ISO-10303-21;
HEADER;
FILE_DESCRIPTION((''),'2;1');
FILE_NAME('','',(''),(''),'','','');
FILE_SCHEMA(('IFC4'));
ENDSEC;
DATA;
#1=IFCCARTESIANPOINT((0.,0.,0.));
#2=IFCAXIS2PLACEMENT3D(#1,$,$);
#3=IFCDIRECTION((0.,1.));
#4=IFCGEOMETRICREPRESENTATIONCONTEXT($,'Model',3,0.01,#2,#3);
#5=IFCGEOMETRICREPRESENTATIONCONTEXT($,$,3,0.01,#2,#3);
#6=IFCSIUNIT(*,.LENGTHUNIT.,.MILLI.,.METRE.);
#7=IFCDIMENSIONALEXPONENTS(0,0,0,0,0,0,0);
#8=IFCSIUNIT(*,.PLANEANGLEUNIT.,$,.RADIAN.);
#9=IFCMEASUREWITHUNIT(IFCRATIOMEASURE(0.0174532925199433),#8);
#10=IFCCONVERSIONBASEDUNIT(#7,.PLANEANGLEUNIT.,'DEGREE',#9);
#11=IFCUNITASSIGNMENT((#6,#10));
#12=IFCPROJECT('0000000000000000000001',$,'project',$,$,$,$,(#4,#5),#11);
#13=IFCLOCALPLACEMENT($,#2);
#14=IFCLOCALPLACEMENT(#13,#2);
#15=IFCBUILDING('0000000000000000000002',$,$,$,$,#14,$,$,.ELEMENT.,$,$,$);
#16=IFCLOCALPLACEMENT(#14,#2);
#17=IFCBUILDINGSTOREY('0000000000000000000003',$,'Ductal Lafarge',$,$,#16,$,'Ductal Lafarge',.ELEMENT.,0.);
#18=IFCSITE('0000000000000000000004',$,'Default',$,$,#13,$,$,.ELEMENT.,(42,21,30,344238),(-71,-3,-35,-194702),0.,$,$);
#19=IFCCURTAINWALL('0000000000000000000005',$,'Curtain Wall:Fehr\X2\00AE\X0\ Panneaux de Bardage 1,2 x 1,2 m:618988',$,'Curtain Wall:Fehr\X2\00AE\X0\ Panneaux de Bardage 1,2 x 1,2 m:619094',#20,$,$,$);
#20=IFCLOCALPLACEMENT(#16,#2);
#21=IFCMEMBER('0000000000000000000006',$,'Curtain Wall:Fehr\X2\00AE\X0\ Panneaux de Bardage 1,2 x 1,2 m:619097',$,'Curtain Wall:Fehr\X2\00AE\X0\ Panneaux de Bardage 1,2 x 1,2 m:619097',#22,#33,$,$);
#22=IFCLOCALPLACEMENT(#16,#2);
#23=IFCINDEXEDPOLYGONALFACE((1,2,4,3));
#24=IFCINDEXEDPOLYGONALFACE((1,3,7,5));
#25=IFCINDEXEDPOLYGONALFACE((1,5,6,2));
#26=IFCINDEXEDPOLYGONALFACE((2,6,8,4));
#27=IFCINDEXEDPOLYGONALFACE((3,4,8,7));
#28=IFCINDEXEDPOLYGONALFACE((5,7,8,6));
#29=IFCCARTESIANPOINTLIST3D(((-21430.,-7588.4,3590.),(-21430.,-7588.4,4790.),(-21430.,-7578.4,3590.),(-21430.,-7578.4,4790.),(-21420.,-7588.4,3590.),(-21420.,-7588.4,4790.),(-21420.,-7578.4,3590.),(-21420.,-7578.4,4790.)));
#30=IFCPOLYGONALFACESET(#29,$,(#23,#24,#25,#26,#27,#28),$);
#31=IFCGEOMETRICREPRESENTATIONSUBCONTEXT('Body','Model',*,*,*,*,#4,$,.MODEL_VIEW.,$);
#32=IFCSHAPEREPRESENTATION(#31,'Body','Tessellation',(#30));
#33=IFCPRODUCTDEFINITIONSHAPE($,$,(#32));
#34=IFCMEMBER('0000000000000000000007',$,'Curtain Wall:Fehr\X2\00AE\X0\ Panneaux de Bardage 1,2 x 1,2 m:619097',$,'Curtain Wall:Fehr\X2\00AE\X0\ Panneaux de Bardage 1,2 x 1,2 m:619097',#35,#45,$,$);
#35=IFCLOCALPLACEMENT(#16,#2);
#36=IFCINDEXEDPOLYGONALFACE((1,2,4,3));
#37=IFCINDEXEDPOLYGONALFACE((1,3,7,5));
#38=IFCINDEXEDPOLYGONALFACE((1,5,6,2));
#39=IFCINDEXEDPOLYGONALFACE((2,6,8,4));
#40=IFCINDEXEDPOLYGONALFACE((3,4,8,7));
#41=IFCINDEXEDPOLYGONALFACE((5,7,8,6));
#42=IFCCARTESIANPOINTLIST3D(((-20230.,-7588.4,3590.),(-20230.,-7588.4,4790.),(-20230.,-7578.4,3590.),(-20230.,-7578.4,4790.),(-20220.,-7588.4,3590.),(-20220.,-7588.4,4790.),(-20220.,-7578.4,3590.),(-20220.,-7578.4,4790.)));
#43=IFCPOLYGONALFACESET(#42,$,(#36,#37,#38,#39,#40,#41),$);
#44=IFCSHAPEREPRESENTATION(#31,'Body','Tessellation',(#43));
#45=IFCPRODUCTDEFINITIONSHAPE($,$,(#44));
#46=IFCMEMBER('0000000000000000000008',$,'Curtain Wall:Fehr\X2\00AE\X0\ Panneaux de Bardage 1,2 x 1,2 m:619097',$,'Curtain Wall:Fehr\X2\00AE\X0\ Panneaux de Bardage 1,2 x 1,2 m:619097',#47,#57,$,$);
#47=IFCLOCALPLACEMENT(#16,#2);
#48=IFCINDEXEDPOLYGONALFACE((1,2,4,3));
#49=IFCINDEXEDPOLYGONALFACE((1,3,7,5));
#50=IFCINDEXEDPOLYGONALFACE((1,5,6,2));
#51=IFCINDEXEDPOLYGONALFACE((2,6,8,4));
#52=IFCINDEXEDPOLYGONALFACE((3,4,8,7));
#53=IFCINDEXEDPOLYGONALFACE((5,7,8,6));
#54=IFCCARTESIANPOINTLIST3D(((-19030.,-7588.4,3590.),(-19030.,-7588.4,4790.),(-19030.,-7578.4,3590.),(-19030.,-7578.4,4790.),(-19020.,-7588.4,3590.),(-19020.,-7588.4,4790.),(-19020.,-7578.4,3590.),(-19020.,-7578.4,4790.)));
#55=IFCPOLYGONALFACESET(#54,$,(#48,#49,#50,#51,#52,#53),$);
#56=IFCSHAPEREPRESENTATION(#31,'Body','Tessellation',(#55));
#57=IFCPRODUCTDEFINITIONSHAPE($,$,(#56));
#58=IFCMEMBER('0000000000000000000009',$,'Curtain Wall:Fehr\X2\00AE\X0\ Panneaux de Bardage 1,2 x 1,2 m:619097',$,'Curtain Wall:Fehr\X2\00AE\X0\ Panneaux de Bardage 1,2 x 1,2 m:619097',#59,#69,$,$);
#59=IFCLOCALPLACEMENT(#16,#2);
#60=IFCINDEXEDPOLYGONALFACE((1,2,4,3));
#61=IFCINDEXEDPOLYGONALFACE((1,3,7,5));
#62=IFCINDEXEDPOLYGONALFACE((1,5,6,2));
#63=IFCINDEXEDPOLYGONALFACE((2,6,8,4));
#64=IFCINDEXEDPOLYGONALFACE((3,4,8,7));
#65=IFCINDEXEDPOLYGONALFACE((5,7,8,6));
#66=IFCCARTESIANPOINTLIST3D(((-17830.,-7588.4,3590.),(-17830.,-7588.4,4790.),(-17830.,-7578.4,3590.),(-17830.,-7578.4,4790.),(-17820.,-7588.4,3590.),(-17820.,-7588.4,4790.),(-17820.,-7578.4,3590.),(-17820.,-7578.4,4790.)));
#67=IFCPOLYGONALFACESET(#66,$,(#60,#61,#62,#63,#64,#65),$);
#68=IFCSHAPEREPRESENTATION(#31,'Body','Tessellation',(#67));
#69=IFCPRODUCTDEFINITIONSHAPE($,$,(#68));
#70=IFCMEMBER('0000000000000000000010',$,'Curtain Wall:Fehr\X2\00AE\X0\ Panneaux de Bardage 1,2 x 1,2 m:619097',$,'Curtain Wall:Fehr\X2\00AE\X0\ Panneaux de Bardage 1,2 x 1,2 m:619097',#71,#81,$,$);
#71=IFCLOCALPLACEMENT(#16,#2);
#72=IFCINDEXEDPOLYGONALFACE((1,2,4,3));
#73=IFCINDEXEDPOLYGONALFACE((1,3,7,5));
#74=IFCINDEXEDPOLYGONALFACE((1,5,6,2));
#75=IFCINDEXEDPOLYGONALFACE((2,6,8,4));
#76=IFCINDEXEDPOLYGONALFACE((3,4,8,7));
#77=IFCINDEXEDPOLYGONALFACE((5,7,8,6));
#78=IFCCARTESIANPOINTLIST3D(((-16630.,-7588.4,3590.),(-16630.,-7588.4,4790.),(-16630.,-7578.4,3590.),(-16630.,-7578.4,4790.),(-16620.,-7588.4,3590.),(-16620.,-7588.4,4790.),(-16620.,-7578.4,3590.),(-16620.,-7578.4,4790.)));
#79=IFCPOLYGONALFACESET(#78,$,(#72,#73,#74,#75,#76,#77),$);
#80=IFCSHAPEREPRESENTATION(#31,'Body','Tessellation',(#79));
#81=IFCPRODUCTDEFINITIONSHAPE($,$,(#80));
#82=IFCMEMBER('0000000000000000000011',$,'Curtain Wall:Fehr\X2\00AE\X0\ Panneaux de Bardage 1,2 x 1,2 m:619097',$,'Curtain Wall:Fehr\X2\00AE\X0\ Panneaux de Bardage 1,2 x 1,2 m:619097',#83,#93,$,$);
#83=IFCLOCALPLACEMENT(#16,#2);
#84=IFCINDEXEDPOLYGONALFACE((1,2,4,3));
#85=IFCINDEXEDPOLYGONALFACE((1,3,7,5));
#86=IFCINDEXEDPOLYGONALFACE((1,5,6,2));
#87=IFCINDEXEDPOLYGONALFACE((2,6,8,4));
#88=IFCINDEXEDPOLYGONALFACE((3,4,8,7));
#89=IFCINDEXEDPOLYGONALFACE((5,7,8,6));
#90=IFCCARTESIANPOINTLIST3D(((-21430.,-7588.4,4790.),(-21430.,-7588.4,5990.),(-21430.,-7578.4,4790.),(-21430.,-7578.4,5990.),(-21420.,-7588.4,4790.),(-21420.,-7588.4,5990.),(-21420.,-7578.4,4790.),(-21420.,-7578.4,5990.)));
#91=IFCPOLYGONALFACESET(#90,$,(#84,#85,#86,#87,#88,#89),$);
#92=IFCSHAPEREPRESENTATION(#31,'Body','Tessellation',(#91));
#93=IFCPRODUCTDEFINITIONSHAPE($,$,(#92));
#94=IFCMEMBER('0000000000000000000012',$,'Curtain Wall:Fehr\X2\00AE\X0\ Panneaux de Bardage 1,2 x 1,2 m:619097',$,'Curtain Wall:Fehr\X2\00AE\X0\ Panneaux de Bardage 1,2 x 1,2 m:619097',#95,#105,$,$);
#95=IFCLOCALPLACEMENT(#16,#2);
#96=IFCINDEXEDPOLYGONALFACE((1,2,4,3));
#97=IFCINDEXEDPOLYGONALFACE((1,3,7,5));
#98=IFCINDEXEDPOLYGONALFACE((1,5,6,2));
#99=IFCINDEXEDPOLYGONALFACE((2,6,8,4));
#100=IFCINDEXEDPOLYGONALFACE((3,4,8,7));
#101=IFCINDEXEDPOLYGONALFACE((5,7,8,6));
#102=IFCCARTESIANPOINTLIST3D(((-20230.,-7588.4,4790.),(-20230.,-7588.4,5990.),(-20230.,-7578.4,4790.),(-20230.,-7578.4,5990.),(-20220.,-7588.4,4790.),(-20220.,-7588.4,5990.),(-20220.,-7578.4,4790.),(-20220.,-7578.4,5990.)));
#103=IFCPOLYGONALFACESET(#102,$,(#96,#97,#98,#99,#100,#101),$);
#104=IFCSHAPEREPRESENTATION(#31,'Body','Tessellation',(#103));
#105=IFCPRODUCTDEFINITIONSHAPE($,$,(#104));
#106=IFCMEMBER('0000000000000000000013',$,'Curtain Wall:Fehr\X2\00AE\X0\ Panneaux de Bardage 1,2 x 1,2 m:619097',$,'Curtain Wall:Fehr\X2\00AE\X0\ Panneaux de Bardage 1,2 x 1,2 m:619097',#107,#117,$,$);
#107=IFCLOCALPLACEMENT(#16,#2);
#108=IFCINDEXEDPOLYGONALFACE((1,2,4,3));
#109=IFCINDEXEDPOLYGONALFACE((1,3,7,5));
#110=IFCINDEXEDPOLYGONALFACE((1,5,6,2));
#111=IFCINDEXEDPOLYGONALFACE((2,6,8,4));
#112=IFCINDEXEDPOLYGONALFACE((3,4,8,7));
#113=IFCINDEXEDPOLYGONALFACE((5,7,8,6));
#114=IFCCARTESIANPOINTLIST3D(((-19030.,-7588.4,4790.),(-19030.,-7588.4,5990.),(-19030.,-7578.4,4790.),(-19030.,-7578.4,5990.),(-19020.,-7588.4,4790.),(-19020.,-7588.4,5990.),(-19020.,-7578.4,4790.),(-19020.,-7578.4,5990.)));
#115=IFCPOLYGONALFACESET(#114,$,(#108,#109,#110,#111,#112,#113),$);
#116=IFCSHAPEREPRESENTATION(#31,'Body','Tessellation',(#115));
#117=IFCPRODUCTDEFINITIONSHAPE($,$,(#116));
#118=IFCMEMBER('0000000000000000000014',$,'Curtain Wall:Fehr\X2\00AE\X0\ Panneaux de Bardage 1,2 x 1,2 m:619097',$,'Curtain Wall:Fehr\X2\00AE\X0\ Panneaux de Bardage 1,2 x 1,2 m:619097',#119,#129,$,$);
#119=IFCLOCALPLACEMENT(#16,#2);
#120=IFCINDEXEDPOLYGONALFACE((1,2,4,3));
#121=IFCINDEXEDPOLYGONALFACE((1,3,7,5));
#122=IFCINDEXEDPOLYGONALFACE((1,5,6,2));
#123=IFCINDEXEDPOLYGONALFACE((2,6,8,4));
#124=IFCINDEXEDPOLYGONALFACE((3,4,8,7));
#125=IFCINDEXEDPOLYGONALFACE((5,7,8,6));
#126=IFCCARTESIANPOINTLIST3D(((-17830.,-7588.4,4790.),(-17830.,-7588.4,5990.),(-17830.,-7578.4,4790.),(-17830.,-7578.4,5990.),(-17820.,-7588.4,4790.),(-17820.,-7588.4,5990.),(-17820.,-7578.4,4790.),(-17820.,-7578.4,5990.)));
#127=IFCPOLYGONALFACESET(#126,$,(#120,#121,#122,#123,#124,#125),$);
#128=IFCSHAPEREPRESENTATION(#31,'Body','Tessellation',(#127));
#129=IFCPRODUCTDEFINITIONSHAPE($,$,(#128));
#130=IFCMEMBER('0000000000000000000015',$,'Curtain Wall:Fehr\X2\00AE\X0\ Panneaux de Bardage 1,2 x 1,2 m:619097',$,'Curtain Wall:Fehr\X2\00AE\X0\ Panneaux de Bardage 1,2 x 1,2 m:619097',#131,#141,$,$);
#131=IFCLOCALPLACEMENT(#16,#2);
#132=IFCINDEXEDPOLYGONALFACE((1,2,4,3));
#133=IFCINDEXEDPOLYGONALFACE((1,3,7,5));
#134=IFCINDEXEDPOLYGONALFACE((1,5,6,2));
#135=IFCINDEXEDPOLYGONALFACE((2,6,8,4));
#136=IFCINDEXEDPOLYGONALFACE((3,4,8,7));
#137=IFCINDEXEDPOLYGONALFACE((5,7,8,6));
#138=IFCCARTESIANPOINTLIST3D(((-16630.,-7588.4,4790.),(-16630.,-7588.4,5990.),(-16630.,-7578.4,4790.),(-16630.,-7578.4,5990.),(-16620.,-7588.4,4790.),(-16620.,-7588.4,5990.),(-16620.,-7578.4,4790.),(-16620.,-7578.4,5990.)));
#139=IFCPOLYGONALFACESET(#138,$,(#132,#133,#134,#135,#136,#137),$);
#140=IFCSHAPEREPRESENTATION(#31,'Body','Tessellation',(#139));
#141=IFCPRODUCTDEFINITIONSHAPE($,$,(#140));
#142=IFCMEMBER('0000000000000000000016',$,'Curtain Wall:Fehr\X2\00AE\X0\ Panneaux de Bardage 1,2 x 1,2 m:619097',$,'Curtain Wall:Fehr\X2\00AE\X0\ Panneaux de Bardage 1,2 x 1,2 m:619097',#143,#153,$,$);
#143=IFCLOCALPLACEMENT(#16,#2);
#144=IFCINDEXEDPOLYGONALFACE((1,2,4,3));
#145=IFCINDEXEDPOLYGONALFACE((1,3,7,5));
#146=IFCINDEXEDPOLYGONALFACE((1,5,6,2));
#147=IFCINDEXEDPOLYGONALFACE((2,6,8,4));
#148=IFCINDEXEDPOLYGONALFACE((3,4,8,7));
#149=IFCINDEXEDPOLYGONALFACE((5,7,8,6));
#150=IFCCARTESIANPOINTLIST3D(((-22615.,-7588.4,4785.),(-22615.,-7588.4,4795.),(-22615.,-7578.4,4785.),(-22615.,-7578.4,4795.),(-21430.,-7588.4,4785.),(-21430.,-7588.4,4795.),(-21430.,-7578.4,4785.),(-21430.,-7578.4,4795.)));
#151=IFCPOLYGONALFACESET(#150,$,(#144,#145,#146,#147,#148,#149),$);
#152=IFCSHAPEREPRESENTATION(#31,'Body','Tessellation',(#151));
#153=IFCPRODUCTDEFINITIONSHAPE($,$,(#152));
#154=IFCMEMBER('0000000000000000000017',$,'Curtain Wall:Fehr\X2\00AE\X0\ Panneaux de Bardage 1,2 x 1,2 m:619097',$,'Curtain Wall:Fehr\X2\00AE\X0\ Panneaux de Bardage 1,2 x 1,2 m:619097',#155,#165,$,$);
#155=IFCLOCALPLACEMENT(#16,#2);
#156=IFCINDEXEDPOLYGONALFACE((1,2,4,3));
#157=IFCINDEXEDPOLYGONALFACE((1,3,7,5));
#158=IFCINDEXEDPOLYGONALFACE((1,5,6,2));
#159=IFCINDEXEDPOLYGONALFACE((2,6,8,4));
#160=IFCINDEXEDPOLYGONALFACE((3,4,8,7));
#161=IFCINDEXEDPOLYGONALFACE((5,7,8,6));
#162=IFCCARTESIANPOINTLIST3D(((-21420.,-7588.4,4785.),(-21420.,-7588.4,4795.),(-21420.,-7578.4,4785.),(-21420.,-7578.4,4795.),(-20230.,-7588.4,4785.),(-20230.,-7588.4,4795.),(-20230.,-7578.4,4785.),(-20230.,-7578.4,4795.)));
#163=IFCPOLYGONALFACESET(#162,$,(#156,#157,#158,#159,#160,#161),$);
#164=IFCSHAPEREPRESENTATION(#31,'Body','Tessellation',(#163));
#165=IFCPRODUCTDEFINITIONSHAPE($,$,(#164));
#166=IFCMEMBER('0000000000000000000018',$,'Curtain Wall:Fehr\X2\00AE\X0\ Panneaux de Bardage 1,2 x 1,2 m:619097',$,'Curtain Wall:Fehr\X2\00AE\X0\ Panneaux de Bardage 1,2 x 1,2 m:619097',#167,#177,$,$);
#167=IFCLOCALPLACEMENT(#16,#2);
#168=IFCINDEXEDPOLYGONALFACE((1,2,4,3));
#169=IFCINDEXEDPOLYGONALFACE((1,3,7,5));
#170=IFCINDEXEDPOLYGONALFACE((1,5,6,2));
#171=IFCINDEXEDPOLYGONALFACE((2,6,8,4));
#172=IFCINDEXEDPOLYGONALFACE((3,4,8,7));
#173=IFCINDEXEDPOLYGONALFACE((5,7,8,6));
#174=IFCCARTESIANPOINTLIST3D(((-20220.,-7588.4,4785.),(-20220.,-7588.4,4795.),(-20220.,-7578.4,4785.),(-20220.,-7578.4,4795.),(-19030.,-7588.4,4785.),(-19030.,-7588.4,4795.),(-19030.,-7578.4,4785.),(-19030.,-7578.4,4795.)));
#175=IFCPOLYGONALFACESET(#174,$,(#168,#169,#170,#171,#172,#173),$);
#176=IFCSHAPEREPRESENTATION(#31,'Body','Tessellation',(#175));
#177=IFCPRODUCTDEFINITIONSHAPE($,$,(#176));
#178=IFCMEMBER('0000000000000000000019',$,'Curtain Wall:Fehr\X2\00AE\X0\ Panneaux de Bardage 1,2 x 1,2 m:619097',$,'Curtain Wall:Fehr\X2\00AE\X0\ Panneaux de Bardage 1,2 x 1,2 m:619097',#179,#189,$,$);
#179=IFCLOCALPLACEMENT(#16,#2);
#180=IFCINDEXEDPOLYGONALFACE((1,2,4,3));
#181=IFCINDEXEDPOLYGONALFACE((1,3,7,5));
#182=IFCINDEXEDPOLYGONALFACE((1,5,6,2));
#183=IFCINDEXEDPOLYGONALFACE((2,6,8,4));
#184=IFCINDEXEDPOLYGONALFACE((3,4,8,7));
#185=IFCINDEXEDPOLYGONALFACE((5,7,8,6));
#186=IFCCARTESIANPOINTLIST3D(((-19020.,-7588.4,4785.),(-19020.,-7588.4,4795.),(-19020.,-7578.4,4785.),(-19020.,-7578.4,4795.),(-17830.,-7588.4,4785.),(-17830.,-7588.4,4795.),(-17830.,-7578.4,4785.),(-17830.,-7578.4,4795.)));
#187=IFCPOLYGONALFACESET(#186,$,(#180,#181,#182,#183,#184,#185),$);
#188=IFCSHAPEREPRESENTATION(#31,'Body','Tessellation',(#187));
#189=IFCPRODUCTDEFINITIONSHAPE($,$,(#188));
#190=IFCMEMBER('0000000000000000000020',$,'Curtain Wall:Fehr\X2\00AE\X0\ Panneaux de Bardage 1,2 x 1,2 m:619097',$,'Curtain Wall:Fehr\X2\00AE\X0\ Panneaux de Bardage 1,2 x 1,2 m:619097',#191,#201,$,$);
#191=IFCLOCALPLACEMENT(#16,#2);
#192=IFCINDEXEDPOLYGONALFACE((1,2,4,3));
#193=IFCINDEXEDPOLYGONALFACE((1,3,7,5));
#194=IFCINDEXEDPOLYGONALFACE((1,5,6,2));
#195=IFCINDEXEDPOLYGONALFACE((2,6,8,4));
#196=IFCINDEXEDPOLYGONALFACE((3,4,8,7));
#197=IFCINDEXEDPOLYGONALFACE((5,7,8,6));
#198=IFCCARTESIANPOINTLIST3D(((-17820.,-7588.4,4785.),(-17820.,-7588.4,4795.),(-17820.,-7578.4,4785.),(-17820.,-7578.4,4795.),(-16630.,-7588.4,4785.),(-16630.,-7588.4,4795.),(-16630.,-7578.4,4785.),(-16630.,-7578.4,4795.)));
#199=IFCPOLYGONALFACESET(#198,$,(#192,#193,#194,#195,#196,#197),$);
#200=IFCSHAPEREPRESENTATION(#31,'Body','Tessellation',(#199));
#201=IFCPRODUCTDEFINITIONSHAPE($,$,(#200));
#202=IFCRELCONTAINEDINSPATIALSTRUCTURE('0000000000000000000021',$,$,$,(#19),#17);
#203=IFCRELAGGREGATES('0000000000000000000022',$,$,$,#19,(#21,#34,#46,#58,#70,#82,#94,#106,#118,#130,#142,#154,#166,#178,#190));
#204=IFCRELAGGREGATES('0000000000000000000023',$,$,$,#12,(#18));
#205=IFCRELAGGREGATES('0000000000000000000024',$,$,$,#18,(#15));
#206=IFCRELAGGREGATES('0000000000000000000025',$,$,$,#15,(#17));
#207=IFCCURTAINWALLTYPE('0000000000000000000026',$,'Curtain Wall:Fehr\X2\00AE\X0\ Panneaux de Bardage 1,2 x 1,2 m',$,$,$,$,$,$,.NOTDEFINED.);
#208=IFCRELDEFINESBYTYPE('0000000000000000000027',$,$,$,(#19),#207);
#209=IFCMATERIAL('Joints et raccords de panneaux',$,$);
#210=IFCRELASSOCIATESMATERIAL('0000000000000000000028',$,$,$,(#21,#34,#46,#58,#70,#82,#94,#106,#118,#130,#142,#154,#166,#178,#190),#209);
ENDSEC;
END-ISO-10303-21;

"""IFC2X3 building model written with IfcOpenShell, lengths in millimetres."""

from ifc_helpers import new_model, entity, si_unit, converted_unit, direction, frame, frame_2d, origin, origin_2d_with_axis, place, context, subcontext, project, spatial, rectangle, extrude, material, type_object, element, aggregate, save


model = new_model("IFC2X3")

# Units and contexts
model_context = context("Model", 3, precision=0.01, world=origin(), true_north=direction((0.0, 1.0)))
context_of_model = context(None, 3, precision=0.01, world=origin(), true_north=direction((0.0, 1.0)))
body_context = subcontext(model_context, "Body", "Model", "MODEL_VIEW")
ifc_project = project(units=[si_unit("LENGTHUNIT", "METRE", prefix="MILLI"), converted_unit("PLANEANGLEUNIT", "DEGREE", entity("IfcRatioMeasure", 0.0174532925199433), si_unit("PLANEANGLEUNIT", "RADIAN"), dimensions=[0, 0, 0, 0, 0, 0, 0])], contexts=[model_context, context_of_model])

# Site, building, storey
site_placement = place(None, origin())
site = spatial("IfcSite", under=ifc_project, at=site_placement, Name="Default", CompositionType="ELEMENT", RefLatitude=(42, 21, 30, 344238), RefLongitude=(-71, -3, -35, -194702), RefElevation=0.0)
building_placement = place(site_placement, origin())
building = spatial("IfcBuilding", under=site, at=building_placement, CompositionType="ELEMENT")
storey_placement = place(building_placement, origin())
storey = spatial("IfcBuildingStorey", under=building, at=storey_placement, Name="Ductal Lafarge", LongName="Ductal Lafarge", CompositionType="ELEMENT", Elevation=0.0)

# Curtain wall, members
curtain_wall_type = type_object("IfcCurtainWallType", Name="Curtain Wall:Fehr® Panneaux de Bardage 1,2 x 1,2 m", PredefinedType="NOTDEFINED")
curtain_wall_placement = place(storey_placement, origin())
curtain_wall = element("IfcCurtainWall", 1, at=curtain_wall_placement, inside=storey, type_object=curtain_wall_type, Name="Curtain Wall:Fehr® Panneaux de Bardage 1,2 x 1,2 m:618988", ObjectType="Curtain Wall:Fehr® Panneaux de Bardage 1,2 x 1,2 m:619094")
ifc_material = material(Name="Joints et raccords de panneaux")
member_1_placement = place(curtain_wall_placement, frame((-21430.0, -7588.4, 3590.0)))
member_1 = element("IfcMember", 2, at=member_1_placement, material=ifc_material, Name="Curtain Wall:Fehr® Panneaux de Bardage 1,2 x 1,2 m:619097", ObjectType="Curtain Wall:Fehr® Panneaux de Bardage 1,2 x 1,2 m:619097", context=body_context, shape_type="SweptSolid", body=[
    extrude(rectangle(XDim=10.0, YDim=10.0, at=origin_2d_with_axis()), frame((5.0, 5.0, 0.0), z_axis=(0.0, 0.0, 1.0), x_axis=(0.0, 1.0, 0.0)), (0.0, 0.0, 1.0), 1200.0),
])
member_2_placement = place(curtain_wall_placement, frame((-20230.0, -7588.4, 3590.0)))
member_2 = element("IfcMember", 3, at=member_2_placement, material=ifc_material, Name="Curtain Wall:Fehr® Panneaux de Bardage 1,2 x 1,2 m:619097", ObjectType="Curtain Wall:Fehr® Panneaux de Bardage 1,2 x 1,2 m:619097", context=body_context, shape_type="SweptSolid", body=[
    extrude(rectangle(XDim=10.0, YDim=10.0, at=origin_2d_with_axis()), frame((5.0, 5.0, 0.0), z_axis=(0.0, 0.0, 1.0), x_axis=(0.0, 1.0, 0.0)), (0.0, 0.0, 1.0), 1200.0),
])
member_3_placement = place(curtain_wall_placement, frame((-19030.0, -7588.4, 3590.0)))
member_3 = element("IfcMember", 4, at=member_3_placement, material=ifc_material, Name="Curtain Wall:Fehr® Panneaux de Bardage 1,2 x 1,2 m:619097", ObjectType="Curtain Wall:Fehr® Panneaux de Bardage 1,2 x 1,2 m:619097", context=body_context, shape_type="SweptSolid", body=[
    extrude(rectangle(XDim=10.0, YDim=10.0, at=origin_2d_with_axis()), frame((5.0, 5.0, 0.0), z_axis=(0.0, 0.0, 1.0), x_axis=(0.0, 1.0, 0.0)), (0.0, 0.0, 1.0), 1200.0),
])
member_4_placement = place(curtain_wall_placement, frame((-17830.0, -7588.4, 3590.0)))
member_4 = element("IfcMember", 5, at=member_4_placement, material=ifc_material, Name="Curtain Wall:Fehr® Panneaux de Bardage 1,2 x 1,2 m:619097", ObjectType="Curtain Wall:Fehr® Panneaux de Bardage 1,2 x 1,2 m:619097", context=body_context, shape_type="SweptSolid", body=[
    extrude(rectangle(XDim=10.0, YDim=10.0, at=origin_2d_with_axis()), frame((5.0, 5.0, 0.0), z_axis=(0.0, 0.0, 1.0), x_axis=(0.0, 1.0, 0.0)), (0.0, 0.0, 1.0), 1200.0),
])
member_5_placement = place(curtain_wall_placement, frame((-16630.0, -7588.4, 3590.0)))
member_5 = element("IfcMember", 6, at=member_5_placement, material=ifc_material, Name="Curtain Wall:Fehr® Panneaux de Bardage 1,2 x 1,2 m:619097", ObjectType="Curtain Wall:Fehr® Panneaux de Bardage 1,2 x 1,2 m:619097", context=body_context, shape_type="SweptSolid", body=[
    extrude(rectangle(XDim=10.0, YDim=10.0, at=origin_2d_with_axis()), frame((5.0, 5.0, 0.0), z_axis=(0.0, 0.0, 1.0), x_axis=(0.0, 1.0, 0.0)), (0.0, 0.0, 1.0), 1200.0),
])
member_6_placement = place(curtain_wall_placement, frame((-21430.0, -7588.4, 4790.0)))
member_6 = element("IfcMember", 7, at=member_6_placement, material=ifc_material, Name="Curtain Wall:Fehr® Panneaux de Bardage 1,2 x 1,2 m:619097", ObjectType="Curtain Wall:Fehr® Panneaux de Bardage 1,2 x 1,2 m:619097", context=body_context, shape_type="SweptSolid", body=[
    extrude(rectangle(XDim=10.0, YDim=10.0, at=origin_2d_with_axis()), frame((5.0, 5.0, 0.0), z_axis=(0.0, 0.0, 1.0), x_axis=(0.0, 1.0, 0.0)), (0.0, 0.0, 1.0), 1200.0),
])
member_7_placement = place(curtain_wall_placement, frame((-20230.0, -7588.4, 4790.0)))
member_7 = element("IfcMember", 8, at=member_7_placement, material=ifc_material, Name="Curtain Wall:Fehr® Panneaux de Bardage 1,2 x 1,2 m:619097", ObjectType="Curtain Wall:Fehr® Panneaux de Bardage 1,2 x 1,2 m:619097", context=body_context, shape_type="SweptSolid", body=[
    extrude(rectangle(XDim=10.0, YDim=10.0, at=origin_2d_with_axis()), frame((5.0, 5.0, 0.0), z_axis=(0.0, 0.0, 1.0), x_axis=(0.0, 1.0, 0.0)), (0.0, 0.0, 1.0), 1200.0),
])
member_8_placement = place(curtain_wall_placement, frame((-19030.0, -7588.4, 4790.0)))
member_8 = element("IfcMember", 9, at=member_8_placement, material=ifc_material, Name="Curtain Wall:Fehr® Panneaux de Bardage 1,2 x 1,2 m:619097", ObjectType="Curtain Wall:Fehr® Panneaux de Bardage 1,2 x 1,2 m:619097", context=body_context, shape_type="SweptSolid", body=[
    extrude(rectangle(XDim=10.0, YDim=10.0, at=origin_2d_with_axis()), frame((5.0, 5.0, 0.0), z_axis=(0.0, 0.0, 1.0), x_axis=(0.0, 1.0, 0.0)), (0.0, 0.0, 1.0), 1200.0),
])
member_9_placement = place(curtain_wall_placement, frame((-17830.0, -7588.4, 4790.0)))
member_9 = element("IfcMember", 10, at=member_9_placement, material=ifc_material, Name="Curtain Wall:Fehr® Panneaux de Bardage 1,2 x 1,2 m:619097", ObjectType="Curtain Wall:Fehr® Panneaux de Bardage 1,2 x 1,2 m:619097", context=body_context, shape_type="SweptSolid", body=[
    extrude(rectangle(XDim=10.0, YDim=10.0, at=origin_2d_with_axis()), frame((5.0, 5.0, 0.0), z_axis=(0.0, 0.0, 1.0), x_axis=(0.0, 1.0, 0.0)), (0.0, 0.0, 1.0), 1200.0),
])
member_10_placement = place(curtain_wall_placement, frame((-16630.0, -7588.4, 4790.0)))
member_10 = element("IfcMember", 11, at=member_10_placement, material=ifc_material, Name="Curtain Wall:Fehr® Panneaux de Bardage 1,2 x 1,2 m:619097", ObjectType="Curtain Wall:Fehr® Panneaux de Bardage 1,2 x 1,2 m:619097", context=body_context, shape_type="SweptSolid", body=[
    extrude(rectangle(XDim=10.0, YDim=10.0, at=origin_2d_with_axis()), frame((5.0, 5.0, 0.0), z_axis=(0.0, 0.0, 1.0), x_axis=(0.0, 1.0, 0.0)), (0.0, 0.0, 1.0), 1200.0),
])
member_11_placement = place(curtain_wall_placement, frame((-22615.0, -7588.4, 4785.0)))
member_11 = element("IfcMember", 12, at=member_11_placement, material=ifc_material, Name="Curtain Wall:Fehr® Panneaux de Bardage 1,2 x 1,2 m:619097", ObjectType="Curtain Wall:Fehr® Panneaux de Bardage 1,2 x 1,2 m:619097", context=body_context, shape_type="SweptSolid", body=[
    extrude(rectangle(XDim=1185.0, YDim=10.0, at=origin_2d_with_axis()), frame((592.5, 5.0, 0.0), z_axis=(0.0, 0.0, 1.0), x_axis=(-1.0, 0.0, 0.0)), (0.0, 0.0, 1.0), 10.0),
])
member_12_placement = place(curtain_wall_placement, frame((-21420.0, -7588.4, 4785.0)))
member_12 = element("IfcMember", 13, at=member_12_placement, material=ifc_material, Name="Curtain Wall:Fehr® Panneaux de Bardage 1,2 x 1,2 m:619097", ObjectType="Curtain Wall:Fehr® Panneaux de Bardage 1,2 x 1,2 m:619097", context=body_context, shape_type="SweptSolid", body=[
    extrude(rectangle(XDim=1190.0, YDim=10.0, at=frame_2d((0.0, 0.0), x_axis=(1.0, 0.0))), frame((595.0, 5.0, 0.0), z_axis=(0.0, 0.0, 1.0), x_axis=(-1.0, 0.0, 0.0)), (0.0, 0.0, 1.0), 10.0),
])
member_13_placement = place(curtain_wall_placement, frame((-20220.0, -7588.4, 4785.0)))
member_13 = element("IfcMember", 14, at=member_13_placement, material=ifc_material, Name="Curtain Wall:Fehr® Panneaux de Bardage 1,2 x 1,2 m:619097", ObjectType="Curtain Wall:Fehr® Panneaux de Bardage 1,2 x 1,2 m:619097", context=body_context, shape_type="SweptSolid", body=[
    extrude(rectangle(XDim=1190.0, YDim=10.0, at=frame_2d((0.0, 0.0), x_axis=(1.0, 0.0))), frame((595.0, 5.0, 0.0), z_axis=(0.0, 0.0, 1.0), x_axis=(-1.0, 0.0, 0.0)), (0.0, 0.0, 1.0), 10.0),
])
member_14_placement = place(curtain_wall_placement, frame((-19020.0, -7588.4, 4785.0)))
member_14 = element("IfcMember", 15, at=member_14_placement, material=ifc_material, Name="Curtain Wall:Fehr® Panneaux de Bardage 1,2 x 1,2 m:619097", ObjectType="Curtain Wall:Fehr® Panneaux de Bardage 1,2 x 1,2 m:619097", context=body_context, shape_type="SweptSolid", body=[
    extrude(rectangle(XDim=1190.0, YDim=10.0, at=frame_2d((0.0, 0.0), x_axis=(1.0, 0.0))), frame((595.0, 5.0, 0.0), z_axis=(0.0, 0.0, 1.0), x_axis=(-1.0, 0.0, 0.0)), (0.0, 0.0, 1.0), 10.0),
])
member_15_placement = place(curtain_wall_placement, frame((-17820.0, -7588.4, 4785.0)))
member_15 = element("IfcMember", 16, at=member_15_placement, material=ifc_material, Name="Curtain Wall:Fehr® Panneaux de Bardage 1,2 x 1,2 m:619097", ObjectType="Curtain Wall:Fehr® Panneaux de Bardage 1,2 x 1,2 m:619097", context=body_context, shape_type="SweptSolid", body=[
    extrude(rectangle(XDim=1190.0, YDim=10.0, at=frame_2d((0.0, 0.0), x_axis=(1.0, 0.0))), frame((595.0, 5.0, 0.0), z_axis=(0.0, 0.0, 1.0), x_axis=(-1.0, 0.0, 0.0)), (0.0, 0.0, 1.0), 10.0),
])
aggregate(curtain_wall, [member_1, member_2, member_3, member_4, member_5, member_6, member_7, member_8, member_9, member_10, member_11, member_12, member_13, member_14, member_15])

save(model, "model.ifc")
